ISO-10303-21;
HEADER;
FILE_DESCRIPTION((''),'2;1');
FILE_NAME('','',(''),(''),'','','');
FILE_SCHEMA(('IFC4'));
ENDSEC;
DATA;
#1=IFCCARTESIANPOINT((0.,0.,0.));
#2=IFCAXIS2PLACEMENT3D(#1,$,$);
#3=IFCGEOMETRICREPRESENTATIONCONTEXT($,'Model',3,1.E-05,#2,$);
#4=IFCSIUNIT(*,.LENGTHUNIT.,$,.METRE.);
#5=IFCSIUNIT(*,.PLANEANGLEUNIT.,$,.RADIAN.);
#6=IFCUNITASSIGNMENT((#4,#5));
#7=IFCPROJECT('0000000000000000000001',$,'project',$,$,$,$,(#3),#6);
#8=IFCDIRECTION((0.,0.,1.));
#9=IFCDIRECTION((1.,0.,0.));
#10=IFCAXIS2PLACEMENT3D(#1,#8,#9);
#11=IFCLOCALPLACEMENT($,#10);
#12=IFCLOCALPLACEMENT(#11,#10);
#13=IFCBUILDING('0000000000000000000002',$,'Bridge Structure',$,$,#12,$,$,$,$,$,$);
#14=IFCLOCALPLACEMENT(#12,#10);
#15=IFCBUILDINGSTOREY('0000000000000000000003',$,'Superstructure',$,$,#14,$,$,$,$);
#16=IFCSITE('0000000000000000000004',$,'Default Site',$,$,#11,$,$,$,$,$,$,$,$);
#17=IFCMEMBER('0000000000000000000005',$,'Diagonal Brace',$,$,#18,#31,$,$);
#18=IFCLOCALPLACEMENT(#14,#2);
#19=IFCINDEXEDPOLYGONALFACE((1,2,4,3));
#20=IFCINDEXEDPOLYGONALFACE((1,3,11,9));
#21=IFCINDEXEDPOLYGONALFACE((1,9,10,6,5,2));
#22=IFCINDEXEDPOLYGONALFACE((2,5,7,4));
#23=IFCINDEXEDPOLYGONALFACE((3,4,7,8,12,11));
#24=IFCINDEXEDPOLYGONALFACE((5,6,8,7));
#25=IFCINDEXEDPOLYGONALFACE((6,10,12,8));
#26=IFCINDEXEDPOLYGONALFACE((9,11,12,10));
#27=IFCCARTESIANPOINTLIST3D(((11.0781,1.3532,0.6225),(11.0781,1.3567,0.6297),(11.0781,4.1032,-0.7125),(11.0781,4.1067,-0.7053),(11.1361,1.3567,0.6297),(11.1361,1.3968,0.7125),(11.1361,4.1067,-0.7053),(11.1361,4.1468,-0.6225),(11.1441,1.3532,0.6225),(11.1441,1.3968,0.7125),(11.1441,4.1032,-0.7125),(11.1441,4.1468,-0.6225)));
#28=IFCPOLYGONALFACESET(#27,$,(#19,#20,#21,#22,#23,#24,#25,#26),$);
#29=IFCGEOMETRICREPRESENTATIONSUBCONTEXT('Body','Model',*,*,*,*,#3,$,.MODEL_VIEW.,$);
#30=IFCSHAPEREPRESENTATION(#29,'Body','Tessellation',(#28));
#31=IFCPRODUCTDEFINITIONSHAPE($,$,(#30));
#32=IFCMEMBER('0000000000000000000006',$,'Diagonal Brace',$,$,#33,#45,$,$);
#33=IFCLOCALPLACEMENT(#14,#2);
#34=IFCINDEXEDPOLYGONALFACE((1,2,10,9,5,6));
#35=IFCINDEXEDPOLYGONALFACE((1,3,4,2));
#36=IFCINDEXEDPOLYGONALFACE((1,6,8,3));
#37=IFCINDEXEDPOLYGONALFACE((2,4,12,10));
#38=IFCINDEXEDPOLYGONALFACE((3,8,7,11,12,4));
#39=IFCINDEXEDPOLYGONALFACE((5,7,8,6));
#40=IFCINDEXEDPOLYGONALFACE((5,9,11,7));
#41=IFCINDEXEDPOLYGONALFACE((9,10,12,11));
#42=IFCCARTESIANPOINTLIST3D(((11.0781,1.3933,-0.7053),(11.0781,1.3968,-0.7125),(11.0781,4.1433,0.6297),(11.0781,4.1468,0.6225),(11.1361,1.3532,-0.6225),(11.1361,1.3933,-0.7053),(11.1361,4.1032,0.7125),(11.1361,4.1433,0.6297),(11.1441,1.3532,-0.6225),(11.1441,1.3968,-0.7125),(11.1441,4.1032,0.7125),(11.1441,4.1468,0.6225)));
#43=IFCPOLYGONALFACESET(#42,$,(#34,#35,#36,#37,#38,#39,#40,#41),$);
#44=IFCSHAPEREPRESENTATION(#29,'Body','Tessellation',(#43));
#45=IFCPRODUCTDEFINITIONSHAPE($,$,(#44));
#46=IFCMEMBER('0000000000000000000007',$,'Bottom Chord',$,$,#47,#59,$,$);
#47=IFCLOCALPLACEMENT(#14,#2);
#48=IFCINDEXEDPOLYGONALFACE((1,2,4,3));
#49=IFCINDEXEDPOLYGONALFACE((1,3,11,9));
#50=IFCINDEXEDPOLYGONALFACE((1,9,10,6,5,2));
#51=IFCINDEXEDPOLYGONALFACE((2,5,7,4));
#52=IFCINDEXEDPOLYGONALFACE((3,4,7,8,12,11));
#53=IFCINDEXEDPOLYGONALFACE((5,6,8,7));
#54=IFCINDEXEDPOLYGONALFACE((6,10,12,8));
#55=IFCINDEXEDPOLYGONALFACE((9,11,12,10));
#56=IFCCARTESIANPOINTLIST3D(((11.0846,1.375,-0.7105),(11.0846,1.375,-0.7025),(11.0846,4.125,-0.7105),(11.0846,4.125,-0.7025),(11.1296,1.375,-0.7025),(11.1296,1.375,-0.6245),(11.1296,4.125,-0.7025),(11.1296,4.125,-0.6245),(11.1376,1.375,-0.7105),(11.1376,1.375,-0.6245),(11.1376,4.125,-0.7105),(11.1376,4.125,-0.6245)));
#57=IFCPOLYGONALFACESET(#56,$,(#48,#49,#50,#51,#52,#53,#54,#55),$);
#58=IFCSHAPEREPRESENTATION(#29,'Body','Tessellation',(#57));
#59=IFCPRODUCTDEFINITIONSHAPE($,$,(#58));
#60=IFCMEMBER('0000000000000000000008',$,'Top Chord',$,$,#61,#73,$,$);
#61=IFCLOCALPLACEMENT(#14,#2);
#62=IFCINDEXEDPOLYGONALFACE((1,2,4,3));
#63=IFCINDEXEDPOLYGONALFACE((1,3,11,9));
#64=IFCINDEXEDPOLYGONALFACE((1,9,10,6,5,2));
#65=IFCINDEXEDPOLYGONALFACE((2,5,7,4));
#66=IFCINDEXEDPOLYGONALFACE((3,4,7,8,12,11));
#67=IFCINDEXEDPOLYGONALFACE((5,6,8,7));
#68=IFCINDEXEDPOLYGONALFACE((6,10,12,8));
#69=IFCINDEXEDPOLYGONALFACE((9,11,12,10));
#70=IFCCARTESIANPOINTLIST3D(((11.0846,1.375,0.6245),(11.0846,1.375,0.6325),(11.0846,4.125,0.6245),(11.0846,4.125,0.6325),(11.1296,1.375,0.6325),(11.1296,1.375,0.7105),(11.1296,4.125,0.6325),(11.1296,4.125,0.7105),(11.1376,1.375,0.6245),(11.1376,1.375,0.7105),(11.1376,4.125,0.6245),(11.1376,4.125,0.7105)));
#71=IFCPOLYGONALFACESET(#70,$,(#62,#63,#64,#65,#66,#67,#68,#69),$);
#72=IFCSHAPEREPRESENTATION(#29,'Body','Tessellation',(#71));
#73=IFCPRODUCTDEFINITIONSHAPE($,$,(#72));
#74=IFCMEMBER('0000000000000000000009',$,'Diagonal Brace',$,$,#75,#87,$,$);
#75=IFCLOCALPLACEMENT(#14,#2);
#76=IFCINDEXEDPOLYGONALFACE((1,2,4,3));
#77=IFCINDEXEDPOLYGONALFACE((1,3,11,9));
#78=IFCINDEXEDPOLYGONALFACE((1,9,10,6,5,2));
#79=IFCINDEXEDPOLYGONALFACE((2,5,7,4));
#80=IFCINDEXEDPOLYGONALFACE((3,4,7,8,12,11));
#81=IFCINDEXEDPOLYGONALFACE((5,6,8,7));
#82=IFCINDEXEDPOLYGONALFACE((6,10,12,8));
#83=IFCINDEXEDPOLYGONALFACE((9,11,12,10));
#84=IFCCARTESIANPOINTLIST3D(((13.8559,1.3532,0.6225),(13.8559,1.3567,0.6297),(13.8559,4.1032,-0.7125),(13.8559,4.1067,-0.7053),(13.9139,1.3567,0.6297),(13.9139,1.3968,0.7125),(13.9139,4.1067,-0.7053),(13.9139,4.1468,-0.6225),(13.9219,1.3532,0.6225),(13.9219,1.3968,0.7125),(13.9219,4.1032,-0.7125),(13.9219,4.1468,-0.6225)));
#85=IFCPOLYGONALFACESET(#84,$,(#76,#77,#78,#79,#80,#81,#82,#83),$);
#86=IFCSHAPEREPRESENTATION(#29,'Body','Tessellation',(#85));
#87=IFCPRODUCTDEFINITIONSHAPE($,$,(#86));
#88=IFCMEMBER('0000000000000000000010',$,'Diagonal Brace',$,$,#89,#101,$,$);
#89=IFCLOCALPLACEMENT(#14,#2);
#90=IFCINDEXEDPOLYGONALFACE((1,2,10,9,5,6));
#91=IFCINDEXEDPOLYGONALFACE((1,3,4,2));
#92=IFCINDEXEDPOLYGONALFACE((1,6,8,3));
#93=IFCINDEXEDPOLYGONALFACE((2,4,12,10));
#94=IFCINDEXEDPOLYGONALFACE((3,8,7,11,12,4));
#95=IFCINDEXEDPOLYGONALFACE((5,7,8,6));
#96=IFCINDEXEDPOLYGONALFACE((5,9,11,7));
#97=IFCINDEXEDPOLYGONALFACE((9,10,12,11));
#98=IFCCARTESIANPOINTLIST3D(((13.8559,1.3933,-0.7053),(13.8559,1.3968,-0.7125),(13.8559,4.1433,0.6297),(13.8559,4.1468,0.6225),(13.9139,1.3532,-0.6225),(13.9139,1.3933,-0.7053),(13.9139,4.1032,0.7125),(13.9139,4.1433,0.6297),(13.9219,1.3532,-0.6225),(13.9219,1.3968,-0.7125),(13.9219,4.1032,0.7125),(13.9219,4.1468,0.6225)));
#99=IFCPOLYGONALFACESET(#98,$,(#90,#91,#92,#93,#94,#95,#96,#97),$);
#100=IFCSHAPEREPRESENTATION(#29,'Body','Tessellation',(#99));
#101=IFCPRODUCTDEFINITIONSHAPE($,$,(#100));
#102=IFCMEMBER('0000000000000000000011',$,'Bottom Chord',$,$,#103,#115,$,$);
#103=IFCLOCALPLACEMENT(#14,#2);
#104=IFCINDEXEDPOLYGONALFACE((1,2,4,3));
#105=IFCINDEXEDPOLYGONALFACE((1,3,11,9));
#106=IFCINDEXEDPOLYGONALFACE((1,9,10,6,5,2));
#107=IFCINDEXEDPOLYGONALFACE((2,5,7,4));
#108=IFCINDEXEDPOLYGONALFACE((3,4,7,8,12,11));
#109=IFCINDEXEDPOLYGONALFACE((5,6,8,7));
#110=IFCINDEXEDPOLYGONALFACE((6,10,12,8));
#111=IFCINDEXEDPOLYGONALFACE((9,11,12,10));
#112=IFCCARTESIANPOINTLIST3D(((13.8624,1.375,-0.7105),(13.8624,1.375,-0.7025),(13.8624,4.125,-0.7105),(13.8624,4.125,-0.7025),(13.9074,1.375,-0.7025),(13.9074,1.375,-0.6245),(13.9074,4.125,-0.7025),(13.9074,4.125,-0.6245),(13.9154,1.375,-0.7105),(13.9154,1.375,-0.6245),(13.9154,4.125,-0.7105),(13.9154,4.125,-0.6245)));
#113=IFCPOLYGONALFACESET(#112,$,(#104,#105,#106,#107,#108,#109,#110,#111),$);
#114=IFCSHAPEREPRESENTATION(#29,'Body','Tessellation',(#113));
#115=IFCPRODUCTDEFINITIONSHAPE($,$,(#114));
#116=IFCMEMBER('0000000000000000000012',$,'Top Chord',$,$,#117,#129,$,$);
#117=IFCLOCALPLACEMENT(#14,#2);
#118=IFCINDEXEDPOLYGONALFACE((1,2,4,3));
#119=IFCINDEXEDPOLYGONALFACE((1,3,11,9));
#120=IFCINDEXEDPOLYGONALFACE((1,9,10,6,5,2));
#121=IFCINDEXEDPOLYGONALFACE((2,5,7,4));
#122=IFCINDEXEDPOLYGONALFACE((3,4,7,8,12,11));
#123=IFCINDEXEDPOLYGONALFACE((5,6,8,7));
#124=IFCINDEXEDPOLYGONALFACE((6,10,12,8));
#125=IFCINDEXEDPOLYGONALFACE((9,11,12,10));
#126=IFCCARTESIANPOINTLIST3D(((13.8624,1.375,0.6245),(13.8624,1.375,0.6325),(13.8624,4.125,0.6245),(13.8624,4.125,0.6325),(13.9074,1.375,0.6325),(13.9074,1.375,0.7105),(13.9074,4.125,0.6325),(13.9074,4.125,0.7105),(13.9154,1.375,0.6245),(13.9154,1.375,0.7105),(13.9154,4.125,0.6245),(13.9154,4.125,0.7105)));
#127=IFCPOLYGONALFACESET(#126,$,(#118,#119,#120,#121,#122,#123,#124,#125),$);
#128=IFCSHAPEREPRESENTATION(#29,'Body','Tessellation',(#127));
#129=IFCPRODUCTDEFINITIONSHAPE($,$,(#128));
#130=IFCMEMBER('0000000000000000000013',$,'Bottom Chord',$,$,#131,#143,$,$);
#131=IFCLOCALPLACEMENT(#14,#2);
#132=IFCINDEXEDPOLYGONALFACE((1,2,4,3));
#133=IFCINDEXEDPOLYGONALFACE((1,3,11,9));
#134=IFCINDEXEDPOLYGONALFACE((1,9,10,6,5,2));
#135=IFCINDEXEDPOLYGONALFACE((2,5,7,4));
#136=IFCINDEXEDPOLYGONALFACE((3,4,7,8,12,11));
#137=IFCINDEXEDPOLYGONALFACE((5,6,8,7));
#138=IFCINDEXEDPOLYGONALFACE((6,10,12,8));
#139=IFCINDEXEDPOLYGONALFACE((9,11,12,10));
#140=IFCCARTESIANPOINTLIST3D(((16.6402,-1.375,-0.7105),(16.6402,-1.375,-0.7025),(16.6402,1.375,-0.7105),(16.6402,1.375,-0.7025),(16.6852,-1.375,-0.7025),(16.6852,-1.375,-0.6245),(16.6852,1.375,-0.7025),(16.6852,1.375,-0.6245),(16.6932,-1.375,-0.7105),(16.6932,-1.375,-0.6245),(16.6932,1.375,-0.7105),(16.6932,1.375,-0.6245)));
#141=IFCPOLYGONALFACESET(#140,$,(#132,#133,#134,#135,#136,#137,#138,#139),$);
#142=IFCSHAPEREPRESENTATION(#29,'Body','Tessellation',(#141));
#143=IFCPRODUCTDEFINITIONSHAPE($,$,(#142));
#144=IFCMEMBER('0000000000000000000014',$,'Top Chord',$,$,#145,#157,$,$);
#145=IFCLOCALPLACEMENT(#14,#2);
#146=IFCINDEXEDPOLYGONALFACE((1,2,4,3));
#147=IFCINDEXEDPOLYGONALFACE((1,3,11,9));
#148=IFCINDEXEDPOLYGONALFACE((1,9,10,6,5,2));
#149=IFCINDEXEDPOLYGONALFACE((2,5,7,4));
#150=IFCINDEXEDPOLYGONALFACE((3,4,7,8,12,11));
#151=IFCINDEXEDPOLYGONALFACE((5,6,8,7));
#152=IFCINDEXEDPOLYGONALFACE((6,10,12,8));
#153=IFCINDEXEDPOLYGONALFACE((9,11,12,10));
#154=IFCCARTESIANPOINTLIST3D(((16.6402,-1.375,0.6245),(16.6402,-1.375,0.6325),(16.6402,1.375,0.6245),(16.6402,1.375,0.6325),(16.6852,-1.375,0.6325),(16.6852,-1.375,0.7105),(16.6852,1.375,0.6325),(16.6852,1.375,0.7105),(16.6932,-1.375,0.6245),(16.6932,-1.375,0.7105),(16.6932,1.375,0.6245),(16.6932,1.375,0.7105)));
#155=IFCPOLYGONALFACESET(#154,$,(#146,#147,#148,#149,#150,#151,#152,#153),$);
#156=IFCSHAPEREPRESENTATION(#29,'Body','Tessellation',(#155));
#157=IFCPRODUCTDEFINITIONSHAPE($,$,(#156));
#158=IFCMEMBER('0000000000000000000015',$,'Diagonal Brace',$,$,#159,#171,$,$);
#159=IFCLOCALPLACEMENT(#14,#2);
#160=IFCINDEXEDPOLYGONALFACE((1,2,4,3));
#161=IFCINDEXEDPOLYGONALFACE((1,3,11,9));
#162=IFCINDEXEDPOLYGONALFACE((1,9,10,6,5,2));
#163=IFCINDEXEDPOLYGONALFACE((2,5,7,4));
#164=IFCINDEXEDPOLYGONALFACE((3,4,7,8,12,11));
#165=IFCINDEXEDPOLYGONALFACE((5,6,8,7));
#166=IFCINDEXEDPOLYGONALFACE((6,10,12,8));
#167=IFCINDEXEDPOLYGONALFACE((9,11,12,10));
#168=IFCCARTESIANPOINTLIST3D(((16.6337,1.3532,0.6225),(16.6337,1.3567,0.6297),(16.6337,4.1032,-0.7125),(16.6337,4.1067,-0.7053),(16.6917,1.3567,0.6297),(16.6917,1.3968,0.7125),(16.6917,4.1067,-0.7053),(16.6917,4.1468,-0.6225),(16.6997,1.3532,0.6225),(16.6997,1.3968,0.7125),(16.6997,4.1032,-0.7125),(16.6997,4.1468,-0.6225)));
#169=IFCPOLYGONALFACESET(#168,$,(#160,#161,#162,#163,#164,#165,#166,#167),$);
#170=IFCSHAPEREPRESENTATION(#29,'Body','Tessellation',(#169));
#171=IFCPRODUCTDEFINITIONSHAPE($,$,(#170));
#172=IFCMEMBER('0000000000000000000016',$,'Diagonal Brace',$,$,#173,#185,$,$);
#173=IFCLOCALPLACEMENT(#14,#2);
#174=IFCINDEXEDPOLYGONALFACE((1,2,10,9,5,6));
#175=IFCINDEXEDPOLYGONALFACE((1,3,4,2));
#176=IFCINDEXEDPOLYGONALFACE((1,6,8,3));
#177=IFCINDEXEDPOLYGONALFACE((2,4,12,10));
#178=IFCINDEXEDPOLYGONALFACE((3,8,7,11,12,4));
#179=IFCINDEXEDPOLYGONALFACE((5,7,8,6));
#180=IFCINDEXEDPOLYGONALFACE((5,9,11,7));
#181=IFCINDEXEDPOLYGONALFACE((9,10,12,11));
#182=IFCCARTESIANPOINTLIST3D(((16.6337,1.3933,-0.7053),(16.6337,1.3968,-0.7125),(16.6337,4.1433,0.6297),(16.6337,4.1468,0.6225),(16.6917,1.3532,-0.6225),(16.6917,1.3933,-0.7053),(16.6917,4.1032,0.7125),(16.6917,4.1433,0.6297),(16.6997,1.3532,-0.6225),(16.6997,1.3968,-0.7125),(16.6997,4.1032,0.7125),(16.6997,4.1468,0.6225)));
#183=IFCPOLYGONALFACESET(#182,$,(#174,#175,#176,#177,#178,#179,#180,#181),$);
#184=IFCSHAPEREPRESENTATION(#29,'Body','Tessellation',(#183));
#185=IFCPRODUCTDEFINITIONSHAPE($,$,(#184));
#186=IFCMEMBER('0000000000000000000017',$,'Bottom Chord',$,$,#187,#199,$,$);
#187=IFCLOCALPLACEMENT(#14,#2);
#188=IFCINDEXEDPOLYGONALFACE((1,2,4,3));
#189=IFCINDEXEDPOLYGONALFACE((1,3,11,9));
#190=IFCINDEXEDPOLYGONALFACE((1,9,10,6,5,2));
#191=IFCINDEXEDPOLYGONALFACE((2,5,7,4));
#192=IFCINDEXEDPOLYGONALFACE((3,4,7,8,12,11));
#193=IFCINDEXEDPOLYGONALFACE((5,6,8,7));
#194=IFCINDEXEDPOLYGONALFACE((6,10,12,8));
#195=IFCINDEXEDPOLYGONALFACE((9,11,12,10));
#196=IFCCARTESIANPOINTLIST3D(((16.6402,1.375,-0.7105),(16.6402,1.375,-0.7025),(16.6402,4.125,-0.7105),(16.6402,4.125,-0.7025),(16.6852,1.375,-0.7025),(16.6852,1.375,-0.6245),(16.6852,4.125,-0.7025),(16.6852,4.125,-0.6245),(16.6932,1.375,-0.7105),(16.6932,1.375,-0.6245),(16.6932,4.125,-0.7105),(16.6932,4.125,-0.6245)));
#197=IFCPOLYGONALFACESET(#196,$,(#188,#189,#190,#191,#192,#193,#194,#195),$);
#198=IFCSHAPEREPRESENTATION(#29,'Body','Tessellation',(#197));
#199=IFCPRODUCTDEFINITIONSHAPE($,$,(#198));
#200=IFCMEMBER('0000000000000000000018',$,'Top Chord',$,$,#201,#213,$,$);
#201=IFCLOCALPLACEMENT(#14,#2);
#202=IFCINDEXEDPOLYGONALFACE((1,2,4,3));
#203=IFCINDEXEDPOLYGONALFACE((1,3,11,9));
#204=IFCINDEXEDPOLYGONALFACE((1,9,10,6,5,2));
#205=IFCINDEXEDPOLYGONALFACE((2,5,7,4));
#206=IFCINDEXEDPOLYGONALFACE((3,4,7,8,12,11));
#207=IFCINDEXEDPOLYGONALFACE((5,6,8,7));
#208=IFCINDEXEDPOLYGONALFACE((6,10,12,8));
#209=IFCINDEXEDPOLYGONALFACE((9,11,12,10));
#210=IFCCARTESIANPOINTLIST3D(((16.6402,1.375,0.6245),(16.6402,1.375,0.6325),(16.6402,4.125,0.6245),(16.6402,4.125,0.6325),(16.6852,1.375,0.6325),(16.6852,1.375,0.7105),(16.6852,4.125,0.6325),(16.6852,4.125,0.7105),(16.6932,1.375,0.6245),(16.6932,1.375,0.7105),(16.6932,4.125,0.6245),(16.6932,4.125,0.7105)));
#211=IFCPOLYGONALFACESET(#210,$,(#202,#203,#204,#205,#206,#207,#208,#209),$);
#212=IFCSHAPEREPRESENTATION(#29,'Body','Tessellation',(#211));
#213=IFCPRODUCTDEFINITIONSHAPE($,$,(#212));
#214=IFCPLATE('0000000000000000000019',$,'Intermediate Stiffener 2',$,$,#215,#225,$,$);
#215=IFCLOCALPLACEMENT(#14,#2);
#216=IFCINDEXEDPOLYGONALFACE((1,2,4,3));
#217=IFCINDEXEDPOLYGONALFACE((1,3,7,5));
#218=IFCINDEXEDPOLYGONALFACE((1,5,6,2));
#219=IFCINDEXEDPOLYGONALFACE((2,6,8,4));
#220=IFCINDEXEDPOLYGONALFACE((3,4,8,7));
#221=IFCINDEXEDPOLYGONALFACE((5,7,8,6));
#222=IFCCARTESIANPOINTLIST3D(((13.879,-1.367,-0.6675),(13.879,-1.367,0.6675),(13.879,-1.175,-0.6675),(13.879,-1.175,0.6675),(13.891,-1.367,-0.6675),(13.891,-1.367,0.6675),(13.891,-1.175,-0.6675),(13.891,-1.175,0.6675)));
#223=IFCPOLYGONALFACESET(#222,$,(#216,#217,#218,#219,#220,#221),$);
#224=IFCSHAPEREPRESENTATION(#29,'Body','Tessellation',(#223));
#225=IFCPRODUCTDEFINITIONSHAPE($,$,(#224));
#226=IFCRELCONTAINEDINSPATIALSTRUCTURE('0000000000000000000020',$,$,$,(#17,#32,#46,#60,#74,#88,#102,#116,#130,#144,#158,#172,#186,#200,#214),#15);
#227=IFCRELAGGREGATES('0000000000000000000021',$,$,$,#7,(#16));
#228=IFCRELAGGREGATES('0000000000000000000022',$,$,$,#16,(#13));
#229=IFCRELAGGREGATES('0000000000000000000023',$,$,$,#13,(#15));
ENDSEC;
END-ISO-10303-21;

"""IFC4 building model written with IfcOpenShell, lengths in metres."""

from ifc_helpers import new_model, si_unit, frame, origin, origin_with_axes, origin_2d_with_axis, place, context, subcontext, project, spatial, rectangle, l_section, extrude, element, save


model = new_model("IFC4")

# Units and contexts
model_context = context("Model", 3, precision=1e-05, world=origin())
body_context = subcontext(model_context, "Body", "Model", "MODEL_VIEW")
ifc_project = project(units=[si_unit("LENGTHUNIT", "METRE"), si_unit("PLANEANGLEUNIT", "RADIAN")], contexts=[model_context])

# Site, building, storey
site_placement = place(None, origin_with_axes())
site = spatial("IfcSite", under=ifc_project, at=site_placement, Name="Default Site")
building_placement = place(site_placement, origin_with_axes())
building = spatial("IfcBuilding", under=site, at=building_placement, Name="Bridge Structure")
storey_placement = place(building_placement, origin_with_axes())
storey = spatial("IfcBuildingStorey", under=building, at=storey_placement, Name="Superstructure")

# Members
for number, where, z_axis, x_axis, name in (
    (1, (11.1111, 1.375, 0.6675), (0.0, 0.8996, -0.436715), (-1.0, 0.0, 0.0), "Diagonal Brace"),
    (2, (11.1111, 1.375, -0.6675), (0.0, 0.8996, 0.436715), (-1.0, 0.0, 0.0), "Diagonal Brace"),
):
    element("IfcMember", number, at=place(storey_placement, frame(where, z_axis=z_axis, x_axis=x_axis)), inside=storey, Name=name, context=body_context, shape_type="SweptSolid", body=[
        extrude(l_section(Depth=0.1, Width=0.066, Thickness=0.008, at=origin_2d_with_axis()), origin_with_axes(), (0.0, 0.0, 1.0), 3.0569),
    ])
for number, where, z_axis, x_axis, name in (
    (3, (11.1111, 1.375, -0.6675), (0.0, 1.0, 0.0), (-1.0, 0.0, 0.0), "Bottom Chord"),
    (4, (11.1111, 1.375, 0.6675), (0.0, 1.0, 0.0), (-1.0, 0.0, 0.0), "Top Chord"),
):
    element("IfcMember", number, at=place(storey_placement, frame(where, z_axis=z_axis, x_axis=x_axis)), inside=storey, Name=name, context=body_context, shape_type="SweptSolid", body=[
        extrude(l_section(Depth=0.086, Width=0.053, Thickness=0.008, at=origin_2d_with_axis()), origin_with_axes(), (0.0, 0.0, 1.0), 2.75),
    ])
for number, where, z_axis, x_axis, name in (
    (5, (13.8889, 1.375, 0.6675), (0.0, 0.8996, -0.436715), (-1.0, 0.0, 0.0), "Diagonal Brace"),
    (6, (13.8889, 1.375, -0.6675), (0.0, 0.8996, 0.436715), (-1.0, 0.0, 0.0), "Diagonal Brace"),
):
    element("IfcMember", number, at=place(storey_placement, frame(where, z_axis=z_axis, x_axis=x_axis)), inside=storey, Name=name, context=body_context, shape_type="SweptSolid", body=[
        extrude(l_section(Depth=0.1, Width=0.066, Thickness=0.008, at=origin_2d_with_axis()), origin_with_axes(), (0.0, 0.0, 1.0), 3.0569),
    ])
for number, where, z_axis, x_axis, name in (
    (7, (13.8889, 1.375, -0.6675), (0.0, 1.0, 0.0), (-1.0, 0.0, 0.0), "Bottom Chord"),
    (8, (13.8889, 1.375, 0.6675), (0.0, 1.0, 0.0), (-1.0, 0.0, 0.0), "Top Chord"),
    (9, (16.6667, -1.375, -0.6675), (0.0, 1.0, 0.0), (-1.0, 0.0, 0.0), "Bottom Chord"),
    (10, (16.6667, -1.375, 0.6675), (0.0, 1.0, 0.0), (-1.0, 0.0, 0.0), "Top Chord"),
):
    element("IfcMember", number, at=place(storey_placement, frame(where, z_axis=z_axis, x_axis=x_axis)), inside=storey, Name=name, context=body_context, shape_type="SweptSolid", body=[
        extrude(l_section(Depth=0.086, Width=0.053, Thickness=0.008, at=origin_2d_with_axis()), origin_with_axes(), (0.0, 0.0, 1.0), 2.75),
    ])
for number, where, z_axis, x_axis, name in (
    (11, (16.6667, 1.375, 0.6675), (0.0, 0.8996, -0.436715), (-1.0, 0.0, 0.0), "Diagonal Brace"),
    (12, (16.6667, 1.375, -0.6675), (0.0, 0.8996, 0.436715), (-1.0, 0.0, 0.0), "Diagonal Brace"),
):
    element("IfcMember", number, at=place(storey_placement, frame(where, z_axis=z_axis, x_axis=x_axis)), inside=storey, Name=name, context=body_context, shape_type="SweptSolid", body=[
        extrude(l_section(Depth=0.1, Width=0.066, Thickness=0.008, at=origin_2d_with_axis()), origin_with_axes(), (0.0, 0.0, 1.0), 3.0569),
    ])
for number, where, z_axis, x_axis, name in (
    (13, (16.6667, 1.375, -0.6675), (0.0, 1.0, 0.0), (-1.0, 0.0, 0.0), "Bottom Chord"),
    (14, (16.6667, 1.375, 0.6675), (0.0, 1.0, 0.0), (-1.0, 0.0, 0.0), "Top Chord"),
):
    element("IfcMember", number, at=place(storey_placement, frame(where, z_axis=z_axis, x_axis=x_axis)), inside=storey, Name=name, context=body_context, shape_type="SweptSolid", body=[
        extrude(l_section(Depth=0.086, Width=0.053, Thickness=0.008, at=origin_2d_with_axis()), origin_with_axes(), (0.0, 0.0, 1.0), 2.75),
    ])

# Plate
for number, where, z_axis, x_axis, name in (
    (15, (13.885, -1.271, -0.6675), (0.0, 0.0, 1.0), (1.0, 0.0, 0.0), "Intermediate Stiffener 2"),
):
    element("IfcPlate", number, at=place(storey_placement, frame(where, z_axis=z_axis, x_axis=x_axis)), inside=storey, Name=name, context=body_context, shape_type="SweptSolid", body=[
        extrude(rectangle(XDim=0.012, YDim=0.192, at=origin_2d_with_axis()), origin_with_axes(), (0.0, 0.0, 1.0), 1.335),
    ])

save(model, "model.ifc")
